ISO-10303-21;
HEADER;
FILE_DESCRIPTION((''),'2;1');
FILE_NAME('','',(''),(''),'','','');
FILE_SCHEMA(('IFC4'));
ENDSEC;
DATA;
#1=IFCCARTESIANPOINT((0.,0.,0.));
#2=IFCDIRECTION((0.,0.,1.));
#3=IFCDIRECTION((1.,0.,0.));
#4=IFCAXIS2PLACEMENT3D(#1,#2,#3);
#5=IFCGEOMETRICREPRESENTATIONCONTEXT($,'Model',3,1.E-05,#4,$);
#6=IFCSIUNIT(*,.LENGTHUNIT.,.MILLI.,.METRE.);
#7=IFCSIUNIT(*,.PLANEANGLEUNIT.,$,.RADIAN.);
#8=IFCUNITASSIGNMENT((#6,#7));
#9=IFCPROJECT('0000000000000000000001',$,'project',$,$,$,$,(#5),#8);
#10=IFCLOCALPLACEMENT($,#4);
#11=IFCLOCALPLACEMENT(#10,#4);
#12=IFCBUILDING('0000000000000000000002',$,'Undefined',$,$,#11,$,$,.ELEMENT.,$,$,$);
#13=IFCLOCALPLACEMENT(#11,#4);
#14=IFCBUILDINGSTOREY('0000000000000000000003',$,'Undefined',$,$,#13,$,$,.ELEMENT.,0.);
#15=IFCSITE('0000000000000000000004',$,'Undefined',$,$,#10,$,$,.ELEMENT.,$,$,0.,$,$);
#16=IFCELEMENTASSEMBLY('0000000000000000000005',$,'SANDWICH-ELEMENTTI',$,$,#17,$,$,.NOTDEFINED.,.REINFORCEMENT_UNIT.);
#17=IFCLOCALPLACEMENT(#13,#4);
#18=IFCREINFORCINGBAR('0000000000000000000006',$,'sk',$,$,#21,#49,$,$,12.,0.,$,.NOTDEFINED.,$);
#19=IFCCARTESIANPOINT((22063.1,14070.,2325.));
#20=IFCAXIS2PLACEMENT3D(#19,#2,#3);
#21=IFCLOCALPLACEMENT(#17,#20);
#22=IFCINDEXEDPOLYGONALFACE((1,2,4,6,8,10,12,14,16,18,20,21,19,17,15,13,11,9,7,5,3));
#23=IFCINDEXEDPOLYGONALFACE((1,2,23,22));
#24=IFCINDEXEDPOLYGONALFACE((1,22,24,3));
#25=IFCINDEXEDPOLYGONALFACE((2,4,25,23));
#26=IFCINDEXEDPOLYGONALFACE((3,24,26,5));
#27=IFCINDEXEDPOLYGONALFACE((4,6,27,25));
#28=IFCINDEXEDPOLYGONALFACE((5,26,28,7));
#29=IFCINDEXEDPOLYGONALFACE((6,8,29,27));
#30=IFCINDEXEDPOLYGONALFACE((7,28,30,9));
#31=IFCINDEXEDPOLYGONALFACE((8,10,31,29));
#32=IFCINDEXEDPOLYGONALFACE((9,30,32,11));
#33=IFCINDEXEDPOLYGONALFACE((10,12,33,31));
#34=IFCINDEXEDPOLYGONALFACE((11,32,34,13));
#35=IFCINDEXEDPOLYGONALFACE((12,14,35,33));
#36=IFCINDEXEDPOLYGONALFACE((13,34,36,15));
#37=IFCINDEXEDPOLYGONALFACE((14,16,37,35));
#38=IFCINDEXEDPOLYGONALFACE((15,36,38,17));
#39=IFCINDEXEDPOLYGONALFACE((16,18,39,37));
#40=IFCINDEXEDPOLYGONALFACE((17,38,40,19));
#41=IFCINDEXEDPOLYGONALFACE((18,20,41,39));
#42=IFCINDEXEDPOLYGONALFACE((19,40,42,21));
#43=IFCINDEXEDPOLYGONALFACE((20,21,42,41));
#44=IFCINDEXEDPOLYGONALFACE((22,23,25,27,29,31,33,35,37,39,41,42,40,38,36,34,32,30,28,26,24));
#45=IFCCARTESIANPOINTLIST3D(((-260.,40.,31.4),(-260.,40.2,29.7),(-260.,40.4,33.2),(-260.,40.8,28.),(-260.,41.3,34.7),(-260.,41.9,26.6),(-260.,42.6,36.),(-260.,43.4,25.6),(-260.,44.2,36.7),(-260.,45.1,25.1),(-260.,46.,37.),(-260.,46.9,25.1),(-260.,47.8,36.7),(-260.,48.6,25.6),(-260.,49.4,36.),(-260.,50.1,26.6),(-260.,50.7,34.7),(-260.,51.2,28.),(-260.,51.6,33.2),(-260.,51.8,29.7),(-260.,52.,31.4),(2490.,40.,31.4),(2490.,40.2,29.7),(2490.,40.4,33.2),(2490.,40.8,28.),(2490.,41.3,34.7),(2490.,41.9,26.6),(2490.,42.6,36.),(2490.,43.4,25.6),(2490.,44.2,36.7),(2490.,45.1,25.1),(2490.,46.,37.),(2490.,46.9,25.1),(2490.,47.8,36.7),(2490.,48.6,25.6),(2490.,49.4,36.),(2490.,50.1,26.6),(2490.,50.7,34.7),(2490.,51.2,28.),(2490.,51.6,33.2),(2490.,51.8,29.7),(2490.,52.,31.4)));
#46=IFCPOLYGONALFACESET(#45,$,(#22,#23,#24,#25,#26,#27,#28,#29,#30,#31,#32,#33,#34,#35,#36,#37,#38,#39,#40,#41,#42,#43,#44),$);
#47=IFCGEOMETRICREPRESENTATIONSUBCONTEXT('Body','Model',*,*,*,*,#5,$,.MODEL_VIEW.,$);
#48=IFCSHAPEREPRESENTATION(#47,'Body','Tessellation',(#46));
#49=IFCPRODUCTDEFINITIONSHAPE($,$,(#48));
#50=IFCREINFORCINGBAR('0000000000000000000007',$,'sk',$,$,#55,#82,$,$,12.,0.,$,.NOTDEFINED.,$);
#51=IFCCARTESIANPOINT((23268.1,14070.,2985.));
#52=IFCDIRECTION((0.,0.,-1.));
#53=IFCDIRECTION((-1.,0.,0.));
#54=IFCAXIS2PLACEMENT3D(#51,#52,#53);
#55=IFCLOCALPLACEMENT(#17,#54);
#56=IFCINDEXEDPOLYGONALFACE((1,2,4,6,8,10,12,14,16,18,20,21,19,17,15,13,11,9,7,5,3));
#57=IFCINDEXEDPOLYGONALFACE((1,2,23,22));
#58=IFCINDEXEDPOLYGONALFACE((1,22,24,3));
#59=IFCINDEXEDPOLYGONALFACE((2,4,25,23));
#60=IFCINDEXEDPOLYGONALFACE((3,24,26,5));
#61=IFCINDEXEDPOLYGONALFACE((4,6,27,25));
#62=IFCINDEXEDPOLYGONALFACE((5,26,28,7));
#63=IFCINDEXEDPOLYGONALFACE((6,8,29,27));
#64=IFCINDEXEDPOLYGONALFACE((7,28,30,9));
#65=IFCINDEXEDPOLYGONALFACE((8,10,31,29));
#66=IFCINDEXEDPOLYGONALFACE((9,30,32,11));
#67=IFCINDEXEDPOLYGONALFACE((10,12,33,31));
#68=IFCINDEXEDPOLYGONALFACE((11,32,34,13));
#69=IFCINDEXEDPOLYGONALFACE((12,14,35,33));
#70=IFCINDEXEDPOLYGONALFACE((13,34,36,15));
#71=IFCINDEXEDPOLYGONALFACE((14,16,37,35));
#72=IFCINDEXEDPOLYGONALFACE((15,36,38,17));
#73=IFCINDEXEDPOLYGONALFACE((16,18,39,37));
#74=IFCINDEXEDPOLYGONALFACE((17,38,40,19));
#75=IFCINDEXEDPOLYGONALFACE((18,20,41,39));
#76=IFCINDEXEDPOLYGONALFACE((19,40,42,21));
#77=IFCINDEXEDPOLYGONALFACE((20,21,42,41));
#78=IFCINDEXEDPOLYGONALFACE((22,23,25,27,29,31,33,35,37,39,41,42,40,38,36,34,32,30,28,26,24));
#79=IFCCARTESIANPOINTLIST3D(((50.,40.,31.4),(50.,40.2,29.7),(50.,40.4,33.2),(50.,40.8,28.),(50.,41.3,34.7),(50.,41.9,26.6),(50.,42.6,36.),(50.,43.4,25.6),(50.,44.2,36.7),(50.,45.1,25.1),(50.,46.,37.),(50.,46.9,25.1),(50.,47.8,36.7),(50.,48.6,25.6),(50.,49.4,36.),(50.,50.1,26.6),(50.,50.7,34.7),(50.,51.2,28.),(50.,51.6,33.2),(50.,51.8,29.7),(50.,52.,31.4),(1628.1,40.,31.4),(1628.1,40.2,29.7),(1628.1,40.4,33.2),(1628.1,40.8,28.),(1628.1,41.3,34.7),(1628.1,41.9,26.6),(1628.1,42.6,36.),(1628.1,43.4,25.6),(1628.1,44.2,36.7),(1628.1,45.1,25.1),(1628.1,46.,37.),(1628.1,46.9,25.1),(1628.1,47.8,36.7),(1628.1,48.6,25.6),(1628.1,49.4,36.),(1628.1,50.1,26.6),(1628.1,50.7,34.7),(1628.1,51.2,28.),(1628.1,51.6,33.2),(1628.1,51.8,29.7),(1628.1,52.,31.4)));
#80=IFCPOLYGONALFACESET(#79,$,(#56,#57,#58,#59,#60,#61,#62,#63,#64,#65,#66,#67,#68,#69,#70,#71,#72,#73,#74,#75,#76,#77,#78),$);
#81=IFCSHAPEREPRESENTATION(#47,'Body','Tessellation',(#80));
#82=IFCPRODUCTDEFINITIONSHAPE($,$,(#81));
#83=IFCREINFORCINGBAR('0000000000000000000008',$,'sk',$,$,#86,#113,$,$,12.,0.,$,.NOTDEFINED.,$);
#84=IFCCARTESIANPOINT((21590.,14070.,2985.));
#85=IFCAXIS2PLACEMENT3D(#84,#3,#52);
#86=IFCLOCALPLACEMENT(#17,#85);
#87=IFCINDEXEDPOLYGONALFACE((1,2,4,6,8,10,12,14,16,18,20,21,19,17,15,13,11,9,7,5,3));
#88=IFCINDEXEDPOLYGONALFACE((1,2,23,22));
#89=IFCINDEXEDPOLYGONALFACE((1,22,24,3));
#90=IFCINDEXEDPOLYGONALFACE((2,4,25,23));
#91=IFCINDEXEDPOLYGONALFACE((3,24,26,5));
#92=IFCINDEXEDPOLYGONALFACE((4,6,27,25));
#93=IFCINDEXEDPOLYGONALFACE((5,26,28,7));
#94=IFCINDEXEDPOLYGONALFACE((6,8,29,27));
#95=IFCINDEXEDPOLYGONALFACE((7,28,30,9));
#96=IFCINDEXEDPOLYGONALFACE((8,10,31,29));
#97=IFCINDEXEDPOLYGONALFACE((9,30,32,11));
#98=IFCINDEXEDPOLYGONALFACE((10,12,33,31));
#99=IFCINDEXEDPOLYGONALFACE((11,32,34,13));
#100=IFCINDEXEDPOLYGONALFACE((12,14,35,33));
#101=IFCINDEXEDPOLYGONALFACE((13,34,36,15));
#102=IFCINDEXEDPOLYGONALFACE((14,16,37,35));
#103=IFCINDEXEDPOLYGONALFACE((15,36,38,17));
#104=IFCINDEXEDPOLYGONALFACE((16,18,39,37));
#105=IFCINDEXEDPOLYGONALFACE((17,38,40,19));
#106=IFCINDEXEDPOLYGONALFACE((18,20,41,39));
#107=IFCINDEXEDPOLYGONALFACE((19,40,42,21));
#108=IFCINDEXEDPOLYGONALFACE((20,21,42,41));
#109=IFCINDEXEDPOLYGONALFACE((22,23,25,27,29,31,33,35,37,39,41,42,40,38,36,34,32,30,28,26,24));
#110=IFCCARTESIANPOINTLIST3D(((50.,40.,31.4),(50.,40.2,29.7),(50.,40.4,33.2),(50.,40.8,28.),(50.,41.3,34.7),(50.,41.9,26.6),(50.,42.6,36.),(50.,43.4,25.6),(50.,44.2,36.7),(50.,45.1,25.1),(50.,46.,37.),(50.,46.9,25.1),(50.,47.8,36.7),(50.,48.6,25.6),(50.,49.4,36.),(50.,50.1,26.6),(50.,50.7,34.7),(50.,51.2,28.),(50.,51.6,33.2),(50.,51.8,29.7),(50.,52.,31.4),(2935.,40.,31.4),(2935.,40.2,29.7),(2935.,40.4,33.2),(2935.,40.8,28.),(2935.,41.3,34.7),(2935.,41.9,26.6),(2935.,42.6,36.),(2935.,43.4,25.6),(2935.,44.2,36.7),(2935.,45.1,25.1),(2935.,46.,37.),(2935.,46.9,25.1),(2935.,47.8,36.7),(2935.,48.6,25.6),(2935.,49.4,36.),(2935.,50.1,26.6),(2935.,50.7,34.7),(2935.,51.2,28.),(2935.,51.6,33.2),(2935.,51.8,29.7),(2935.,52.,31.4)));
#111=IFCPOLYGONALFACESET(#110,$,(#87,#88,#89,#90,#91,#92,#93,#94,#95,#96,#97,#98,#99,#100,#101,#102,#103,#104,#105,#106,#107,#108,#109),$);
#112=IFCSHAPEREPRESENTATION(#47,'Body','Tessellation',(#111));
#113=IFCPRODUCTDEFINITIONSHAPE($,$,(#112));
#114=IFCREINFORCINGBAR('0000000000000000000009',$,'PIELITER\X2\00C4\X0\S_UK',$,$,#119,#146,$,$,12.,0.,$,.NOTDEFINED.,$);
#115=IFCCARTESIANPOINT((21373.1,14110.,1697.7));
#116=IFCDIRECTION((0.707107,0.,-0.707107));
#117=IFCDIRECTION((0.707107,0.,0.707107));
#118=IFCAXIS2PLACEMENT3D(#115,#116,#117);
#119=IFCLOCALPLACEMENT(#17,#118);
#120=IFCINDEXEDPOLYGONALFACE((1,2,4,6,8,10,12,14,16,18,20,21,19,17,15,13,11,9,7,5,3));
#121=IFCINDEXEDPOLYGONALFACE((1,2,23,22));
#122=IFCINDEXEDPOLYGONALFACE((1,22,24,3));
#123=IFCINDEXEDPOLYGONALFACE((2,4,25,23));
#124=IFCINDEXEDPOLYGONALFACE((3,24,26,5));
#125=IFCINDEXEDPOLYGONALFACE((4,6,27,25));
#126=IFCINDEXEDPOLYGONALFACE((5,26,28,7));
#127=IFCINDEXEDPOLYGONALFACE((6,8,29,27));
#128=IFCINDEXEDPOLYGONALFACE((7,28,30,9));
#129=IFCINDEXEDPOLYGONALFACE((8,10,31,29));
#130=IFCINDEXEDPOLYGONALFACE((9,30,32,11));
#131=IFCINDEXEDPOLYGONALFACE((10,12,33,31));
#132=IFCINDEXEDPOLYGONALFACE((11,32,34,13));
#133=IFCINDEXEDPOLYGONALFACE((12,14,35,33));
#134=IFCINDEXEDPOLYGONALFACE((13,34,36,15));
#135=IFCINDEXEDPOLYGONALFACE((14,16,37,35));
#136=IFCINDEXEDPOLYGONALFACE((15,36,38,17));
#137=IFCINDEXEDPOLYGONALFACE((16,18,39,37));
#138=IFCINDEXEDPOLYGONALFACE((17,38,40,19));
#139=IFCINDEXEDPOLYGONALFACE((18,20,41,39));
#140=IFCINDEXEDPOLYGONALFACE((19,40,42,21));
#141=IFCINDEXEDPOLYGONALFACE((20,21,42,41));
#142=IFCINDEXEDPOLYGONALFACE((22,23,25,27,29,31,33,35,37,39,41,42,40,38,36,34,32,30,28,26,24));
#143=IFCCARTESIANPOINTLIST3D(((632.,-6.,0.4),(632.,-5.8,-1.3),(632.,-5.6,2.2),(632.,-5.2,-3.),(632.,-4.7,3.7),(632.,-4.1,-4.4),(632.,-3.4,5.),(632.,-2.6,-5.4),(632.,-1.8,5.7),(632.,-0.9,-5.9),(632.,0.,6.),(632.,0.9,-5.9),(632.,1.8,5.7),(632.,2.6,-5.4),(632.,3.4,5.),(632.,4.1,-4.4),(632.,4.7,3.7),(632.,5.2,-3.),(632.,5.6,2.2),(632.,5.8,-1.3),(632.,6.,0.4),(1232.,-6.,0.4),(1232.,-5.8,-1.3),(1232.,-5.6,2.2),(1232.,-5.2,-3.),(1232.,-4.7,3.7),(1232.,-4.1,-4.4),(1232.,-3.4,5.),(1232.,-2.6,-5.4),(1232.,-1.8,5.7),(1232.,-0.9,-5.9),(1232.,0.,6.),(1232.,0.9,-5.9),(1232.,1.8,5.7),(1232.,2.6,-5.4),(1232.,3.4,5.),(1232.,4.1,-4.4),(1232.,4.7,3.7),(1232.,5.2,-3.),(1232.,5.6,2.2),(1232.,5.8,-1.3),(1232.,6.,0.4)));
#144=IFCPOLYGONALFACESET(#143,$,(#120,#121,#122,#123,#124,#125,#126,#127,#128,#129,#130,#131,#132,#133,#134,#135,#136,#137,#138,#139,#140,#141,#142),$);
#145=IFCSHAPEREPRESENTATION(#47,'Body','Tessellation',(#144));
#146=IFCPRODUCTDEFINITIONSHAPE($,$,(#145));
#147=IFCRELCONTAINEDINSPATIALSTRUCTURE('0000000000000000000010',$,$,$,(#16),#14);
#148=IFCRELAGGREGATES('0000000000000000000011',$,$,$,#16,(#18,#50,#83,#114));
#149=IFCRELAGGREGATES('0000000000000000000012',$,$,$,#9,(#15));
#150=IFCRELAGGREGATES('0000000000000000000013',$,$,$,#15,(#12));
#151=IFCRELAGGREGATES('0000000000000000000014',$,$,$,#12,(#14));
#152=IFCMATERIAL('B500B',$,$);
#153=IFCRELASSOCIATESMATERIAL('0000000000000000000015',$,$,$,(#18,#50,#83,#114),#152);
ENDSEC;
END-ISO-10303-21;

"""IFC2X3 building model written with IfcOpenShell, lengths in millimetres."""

from ifc_helpers import new_model, entity, si_unit, frame, origin_with_axes, place, context, subcontext, project, spatial, source, transform, mapped, material, element, aggregate, save


model = new_model("IFC2X3")

# Units and contexts
model_context = context("Model", 3, precision=1e-05, world=origin_with_axes())
body_context = subcontext(model_context, "Body", "Model", "MODEL_VIEW")
ifc_project = project(units=[si_unit("LENGTHUNIT", "METRE", prefix="MILLI"), si_unit("PLANEANGLEUNIT", "RADIAN")], contexts=[model_context])

# Site, building, storey
site_placement = place(None, origin_with_axes())
site = spatial("IfcSite", under=ifc_project, at=site_placement, Name="Undefined", CompositionType="ELEMENT", RefElevation=0.0)
building_placement = place(site_placement, origin_with_axes())
building = spatial("IfcBuilding", under=site, at=building_placement, Name="Undefined", CompositionType="ELEMENT")
storey_placement = place(building_placement, origin_with_axes())
storey = spatial("IfcBuildingStorey", under=building, at=storey_placement, Name="Undefined", CompositionType="ELEMENT", Elevation=0.0)

# Element assembly
assembly_1_placement = place(storey_placement, origin_with_axes())
assembly_1 = element("IfcElementAssembly", 1, at=assembly_1_placement, inside=storey, Name="SANDWICH-ELEMENTTI", AssemblyPlace="NOTDEFINED", PredefinedType="REINFORCEMENT_UNIT")

# Reinforcing bars
ifc_material_1 = material(Name="B500B")
shared_shape_1 = source(origin_with_axes(), body_context, "Body", "AdvancedSweptSolid", [
    entity("IfcSweptDiskSolid", entity("IfcTrimmedCurve", entity("IfcLine", entity("IfcCartesianPoint", [0.0, 0.0, 0.0]), entity("IfcVector", entity("IfcDirection", [1.0, 0.0, 0.0]), 1.0)), [entity("IfcParameterValue", 0.0)], [entity("IfcParameterValue", 2750.0001)], True, "PARAMETER"), 6.0, None, 0.0, 2750.0),
])
reinforcing_bar_1_placement = place(assembly_1_placement, frame((22063.1, 14070.0, 2325.0), z_axis=(0.0, 0.0, 1.0), x_axis=(1.0, 0.0, 0.0)))
reinforcing_bar_1 = element("IfcReinforcingBar", 2, at=reinforcing_bar_1_placement, material=ifc_material_1, Name="sk", BarRole="NOTDEFINED", CrossSectionArea=0.0, NominalDiameter=12.0, context=body_context, shape_type="MappedRepresentation", body=[
    mapped(shared_shape_1, transform((-260.0, 46.0, 31.0))),
])
shared_shape_2 = source(origin_with_axes(), body_context, "Body", "AdvancedSweptSolid", [
    entity("IfcSweptDiskSolid", entity("IfcTrimmedCurve", entity("IfcLine", entity("IfcCartesianPoint", [0.0, 0.0, 0.0]), entity("IfcVector", entity("IfcDirection", [1.0, 0.0, 0.0]), 1.0)), [entity("IfcParameterValue", 0.0)], [entity("IfcParameterValue", 1578.1257)], True, "PARAMETER"), 6.0, None, 0.0, 1578.1),
])
reinforcing_bar_2_placement = place(assembly_1_placement, frame((23268.1, 14070.0, 2985.0), z_axis=(0.0, 0.0, -1.0), x_axis=(-1.0, 0.0, 0.0)))
reinforcing_bar_2 = element("IfcReinforcingBar", 3, at=reinforcing_bar_2_placement, material=ifc_material_1, Name="sk", BarRole="NOTDEFINED", CrossSectionArea=0.0, NominalDiameter=12.0, context=body_context, shape_type="MappedRepresentation", body=[
    mapped(shared_shape_2, transform((50.0, 46.0, 31.0))),
])
shared_shape_3 = source(origin_with_axes(), body_context, "Body", "AdvancedSweptSolid", [
    entity("IfcSweptDiskSolid", entity("IfcTrimmedCurve", entity("IfcLine", entity("IfcCartesianPoint", [0.0, 0.0, 0.0]), entity("IfcVector", entity("IfcDirection", [1.0, 0.0, 0.0]), 1.0)), [entity("IfcParameterValue", 0.0)], [entity("IfcParameterValue", 2885.0007)], True, "PARAMETER"), 6.0, None, 0.0, 2885.0),
])
reinforcing_bar_3_placement = place(assembly_1_placement, frame((21590.0, 14070.0, 2985.0), z_axis=(1.0, 0.0, 0.0), x_axis=(0.0, 0.0, -1.0)))
reinforcing_bar_3 = element("IfcReinforcingBar", 4, at=reinforcing_bar_3_placement, material=ifc_material_1, Name="sk", BarRole="NOTDEFINED", CrossSectionArea=0.0, NominalDiameter=12.0, context=body_context, shape_type="MappedRepresentation", body=[
    mapped(shared_shape_3, transform((50.0, 46.0, 31.0))),
])
shared_shape_4 = source(origin_with_axes(), body_context, "Body", "AdvancedSweptSolid", [
    entity("IfcSweptDiskSolid", entity("IfcTrimmedCurve", entity("IfcLine", entity("IfcCartesianPoint", [0.0, 0.0, 0.0]), entity("IfcVector", entity("IfcDirection", [1.0, 0.0, 0.0]), 1.0)), [entity("IfcParameterValue", 0.0)], [entity("IfcParameterValue", 600.0)], True, "PARAMETER"), 6.0, None, 0.0, 600.0),
])
reinforcing_bar_4_placement = place(assembly_1_placement, frame((21373.1, 14110.0, 1697.7), z_axis=(0.707107, 0.0, -0.707107), x_axis=(0.707107, 0.0, 0.707107)))
reinforcing_bar_4 = element("IfcReinforcingBar", 5, at=reinforcing_bar_4_placement, material=ifc_material_1, Name="PIELITERÄS_UK", BarRole="NOTDEFINED", CrossSectionArea=0.0, NominalDiameter=12.0, context=body_context, shape_type="MappedRepresentation", body=[
    mapped(shared_shape_4, transform((632.0, 0.0, 0.0))),
])
aggregate(assembly_1, [reinforcing_bar_1, reinforcing_bar_2, reinforcing_bar_3, reinforcing_bar_4])

save(model, "model.ifc")
